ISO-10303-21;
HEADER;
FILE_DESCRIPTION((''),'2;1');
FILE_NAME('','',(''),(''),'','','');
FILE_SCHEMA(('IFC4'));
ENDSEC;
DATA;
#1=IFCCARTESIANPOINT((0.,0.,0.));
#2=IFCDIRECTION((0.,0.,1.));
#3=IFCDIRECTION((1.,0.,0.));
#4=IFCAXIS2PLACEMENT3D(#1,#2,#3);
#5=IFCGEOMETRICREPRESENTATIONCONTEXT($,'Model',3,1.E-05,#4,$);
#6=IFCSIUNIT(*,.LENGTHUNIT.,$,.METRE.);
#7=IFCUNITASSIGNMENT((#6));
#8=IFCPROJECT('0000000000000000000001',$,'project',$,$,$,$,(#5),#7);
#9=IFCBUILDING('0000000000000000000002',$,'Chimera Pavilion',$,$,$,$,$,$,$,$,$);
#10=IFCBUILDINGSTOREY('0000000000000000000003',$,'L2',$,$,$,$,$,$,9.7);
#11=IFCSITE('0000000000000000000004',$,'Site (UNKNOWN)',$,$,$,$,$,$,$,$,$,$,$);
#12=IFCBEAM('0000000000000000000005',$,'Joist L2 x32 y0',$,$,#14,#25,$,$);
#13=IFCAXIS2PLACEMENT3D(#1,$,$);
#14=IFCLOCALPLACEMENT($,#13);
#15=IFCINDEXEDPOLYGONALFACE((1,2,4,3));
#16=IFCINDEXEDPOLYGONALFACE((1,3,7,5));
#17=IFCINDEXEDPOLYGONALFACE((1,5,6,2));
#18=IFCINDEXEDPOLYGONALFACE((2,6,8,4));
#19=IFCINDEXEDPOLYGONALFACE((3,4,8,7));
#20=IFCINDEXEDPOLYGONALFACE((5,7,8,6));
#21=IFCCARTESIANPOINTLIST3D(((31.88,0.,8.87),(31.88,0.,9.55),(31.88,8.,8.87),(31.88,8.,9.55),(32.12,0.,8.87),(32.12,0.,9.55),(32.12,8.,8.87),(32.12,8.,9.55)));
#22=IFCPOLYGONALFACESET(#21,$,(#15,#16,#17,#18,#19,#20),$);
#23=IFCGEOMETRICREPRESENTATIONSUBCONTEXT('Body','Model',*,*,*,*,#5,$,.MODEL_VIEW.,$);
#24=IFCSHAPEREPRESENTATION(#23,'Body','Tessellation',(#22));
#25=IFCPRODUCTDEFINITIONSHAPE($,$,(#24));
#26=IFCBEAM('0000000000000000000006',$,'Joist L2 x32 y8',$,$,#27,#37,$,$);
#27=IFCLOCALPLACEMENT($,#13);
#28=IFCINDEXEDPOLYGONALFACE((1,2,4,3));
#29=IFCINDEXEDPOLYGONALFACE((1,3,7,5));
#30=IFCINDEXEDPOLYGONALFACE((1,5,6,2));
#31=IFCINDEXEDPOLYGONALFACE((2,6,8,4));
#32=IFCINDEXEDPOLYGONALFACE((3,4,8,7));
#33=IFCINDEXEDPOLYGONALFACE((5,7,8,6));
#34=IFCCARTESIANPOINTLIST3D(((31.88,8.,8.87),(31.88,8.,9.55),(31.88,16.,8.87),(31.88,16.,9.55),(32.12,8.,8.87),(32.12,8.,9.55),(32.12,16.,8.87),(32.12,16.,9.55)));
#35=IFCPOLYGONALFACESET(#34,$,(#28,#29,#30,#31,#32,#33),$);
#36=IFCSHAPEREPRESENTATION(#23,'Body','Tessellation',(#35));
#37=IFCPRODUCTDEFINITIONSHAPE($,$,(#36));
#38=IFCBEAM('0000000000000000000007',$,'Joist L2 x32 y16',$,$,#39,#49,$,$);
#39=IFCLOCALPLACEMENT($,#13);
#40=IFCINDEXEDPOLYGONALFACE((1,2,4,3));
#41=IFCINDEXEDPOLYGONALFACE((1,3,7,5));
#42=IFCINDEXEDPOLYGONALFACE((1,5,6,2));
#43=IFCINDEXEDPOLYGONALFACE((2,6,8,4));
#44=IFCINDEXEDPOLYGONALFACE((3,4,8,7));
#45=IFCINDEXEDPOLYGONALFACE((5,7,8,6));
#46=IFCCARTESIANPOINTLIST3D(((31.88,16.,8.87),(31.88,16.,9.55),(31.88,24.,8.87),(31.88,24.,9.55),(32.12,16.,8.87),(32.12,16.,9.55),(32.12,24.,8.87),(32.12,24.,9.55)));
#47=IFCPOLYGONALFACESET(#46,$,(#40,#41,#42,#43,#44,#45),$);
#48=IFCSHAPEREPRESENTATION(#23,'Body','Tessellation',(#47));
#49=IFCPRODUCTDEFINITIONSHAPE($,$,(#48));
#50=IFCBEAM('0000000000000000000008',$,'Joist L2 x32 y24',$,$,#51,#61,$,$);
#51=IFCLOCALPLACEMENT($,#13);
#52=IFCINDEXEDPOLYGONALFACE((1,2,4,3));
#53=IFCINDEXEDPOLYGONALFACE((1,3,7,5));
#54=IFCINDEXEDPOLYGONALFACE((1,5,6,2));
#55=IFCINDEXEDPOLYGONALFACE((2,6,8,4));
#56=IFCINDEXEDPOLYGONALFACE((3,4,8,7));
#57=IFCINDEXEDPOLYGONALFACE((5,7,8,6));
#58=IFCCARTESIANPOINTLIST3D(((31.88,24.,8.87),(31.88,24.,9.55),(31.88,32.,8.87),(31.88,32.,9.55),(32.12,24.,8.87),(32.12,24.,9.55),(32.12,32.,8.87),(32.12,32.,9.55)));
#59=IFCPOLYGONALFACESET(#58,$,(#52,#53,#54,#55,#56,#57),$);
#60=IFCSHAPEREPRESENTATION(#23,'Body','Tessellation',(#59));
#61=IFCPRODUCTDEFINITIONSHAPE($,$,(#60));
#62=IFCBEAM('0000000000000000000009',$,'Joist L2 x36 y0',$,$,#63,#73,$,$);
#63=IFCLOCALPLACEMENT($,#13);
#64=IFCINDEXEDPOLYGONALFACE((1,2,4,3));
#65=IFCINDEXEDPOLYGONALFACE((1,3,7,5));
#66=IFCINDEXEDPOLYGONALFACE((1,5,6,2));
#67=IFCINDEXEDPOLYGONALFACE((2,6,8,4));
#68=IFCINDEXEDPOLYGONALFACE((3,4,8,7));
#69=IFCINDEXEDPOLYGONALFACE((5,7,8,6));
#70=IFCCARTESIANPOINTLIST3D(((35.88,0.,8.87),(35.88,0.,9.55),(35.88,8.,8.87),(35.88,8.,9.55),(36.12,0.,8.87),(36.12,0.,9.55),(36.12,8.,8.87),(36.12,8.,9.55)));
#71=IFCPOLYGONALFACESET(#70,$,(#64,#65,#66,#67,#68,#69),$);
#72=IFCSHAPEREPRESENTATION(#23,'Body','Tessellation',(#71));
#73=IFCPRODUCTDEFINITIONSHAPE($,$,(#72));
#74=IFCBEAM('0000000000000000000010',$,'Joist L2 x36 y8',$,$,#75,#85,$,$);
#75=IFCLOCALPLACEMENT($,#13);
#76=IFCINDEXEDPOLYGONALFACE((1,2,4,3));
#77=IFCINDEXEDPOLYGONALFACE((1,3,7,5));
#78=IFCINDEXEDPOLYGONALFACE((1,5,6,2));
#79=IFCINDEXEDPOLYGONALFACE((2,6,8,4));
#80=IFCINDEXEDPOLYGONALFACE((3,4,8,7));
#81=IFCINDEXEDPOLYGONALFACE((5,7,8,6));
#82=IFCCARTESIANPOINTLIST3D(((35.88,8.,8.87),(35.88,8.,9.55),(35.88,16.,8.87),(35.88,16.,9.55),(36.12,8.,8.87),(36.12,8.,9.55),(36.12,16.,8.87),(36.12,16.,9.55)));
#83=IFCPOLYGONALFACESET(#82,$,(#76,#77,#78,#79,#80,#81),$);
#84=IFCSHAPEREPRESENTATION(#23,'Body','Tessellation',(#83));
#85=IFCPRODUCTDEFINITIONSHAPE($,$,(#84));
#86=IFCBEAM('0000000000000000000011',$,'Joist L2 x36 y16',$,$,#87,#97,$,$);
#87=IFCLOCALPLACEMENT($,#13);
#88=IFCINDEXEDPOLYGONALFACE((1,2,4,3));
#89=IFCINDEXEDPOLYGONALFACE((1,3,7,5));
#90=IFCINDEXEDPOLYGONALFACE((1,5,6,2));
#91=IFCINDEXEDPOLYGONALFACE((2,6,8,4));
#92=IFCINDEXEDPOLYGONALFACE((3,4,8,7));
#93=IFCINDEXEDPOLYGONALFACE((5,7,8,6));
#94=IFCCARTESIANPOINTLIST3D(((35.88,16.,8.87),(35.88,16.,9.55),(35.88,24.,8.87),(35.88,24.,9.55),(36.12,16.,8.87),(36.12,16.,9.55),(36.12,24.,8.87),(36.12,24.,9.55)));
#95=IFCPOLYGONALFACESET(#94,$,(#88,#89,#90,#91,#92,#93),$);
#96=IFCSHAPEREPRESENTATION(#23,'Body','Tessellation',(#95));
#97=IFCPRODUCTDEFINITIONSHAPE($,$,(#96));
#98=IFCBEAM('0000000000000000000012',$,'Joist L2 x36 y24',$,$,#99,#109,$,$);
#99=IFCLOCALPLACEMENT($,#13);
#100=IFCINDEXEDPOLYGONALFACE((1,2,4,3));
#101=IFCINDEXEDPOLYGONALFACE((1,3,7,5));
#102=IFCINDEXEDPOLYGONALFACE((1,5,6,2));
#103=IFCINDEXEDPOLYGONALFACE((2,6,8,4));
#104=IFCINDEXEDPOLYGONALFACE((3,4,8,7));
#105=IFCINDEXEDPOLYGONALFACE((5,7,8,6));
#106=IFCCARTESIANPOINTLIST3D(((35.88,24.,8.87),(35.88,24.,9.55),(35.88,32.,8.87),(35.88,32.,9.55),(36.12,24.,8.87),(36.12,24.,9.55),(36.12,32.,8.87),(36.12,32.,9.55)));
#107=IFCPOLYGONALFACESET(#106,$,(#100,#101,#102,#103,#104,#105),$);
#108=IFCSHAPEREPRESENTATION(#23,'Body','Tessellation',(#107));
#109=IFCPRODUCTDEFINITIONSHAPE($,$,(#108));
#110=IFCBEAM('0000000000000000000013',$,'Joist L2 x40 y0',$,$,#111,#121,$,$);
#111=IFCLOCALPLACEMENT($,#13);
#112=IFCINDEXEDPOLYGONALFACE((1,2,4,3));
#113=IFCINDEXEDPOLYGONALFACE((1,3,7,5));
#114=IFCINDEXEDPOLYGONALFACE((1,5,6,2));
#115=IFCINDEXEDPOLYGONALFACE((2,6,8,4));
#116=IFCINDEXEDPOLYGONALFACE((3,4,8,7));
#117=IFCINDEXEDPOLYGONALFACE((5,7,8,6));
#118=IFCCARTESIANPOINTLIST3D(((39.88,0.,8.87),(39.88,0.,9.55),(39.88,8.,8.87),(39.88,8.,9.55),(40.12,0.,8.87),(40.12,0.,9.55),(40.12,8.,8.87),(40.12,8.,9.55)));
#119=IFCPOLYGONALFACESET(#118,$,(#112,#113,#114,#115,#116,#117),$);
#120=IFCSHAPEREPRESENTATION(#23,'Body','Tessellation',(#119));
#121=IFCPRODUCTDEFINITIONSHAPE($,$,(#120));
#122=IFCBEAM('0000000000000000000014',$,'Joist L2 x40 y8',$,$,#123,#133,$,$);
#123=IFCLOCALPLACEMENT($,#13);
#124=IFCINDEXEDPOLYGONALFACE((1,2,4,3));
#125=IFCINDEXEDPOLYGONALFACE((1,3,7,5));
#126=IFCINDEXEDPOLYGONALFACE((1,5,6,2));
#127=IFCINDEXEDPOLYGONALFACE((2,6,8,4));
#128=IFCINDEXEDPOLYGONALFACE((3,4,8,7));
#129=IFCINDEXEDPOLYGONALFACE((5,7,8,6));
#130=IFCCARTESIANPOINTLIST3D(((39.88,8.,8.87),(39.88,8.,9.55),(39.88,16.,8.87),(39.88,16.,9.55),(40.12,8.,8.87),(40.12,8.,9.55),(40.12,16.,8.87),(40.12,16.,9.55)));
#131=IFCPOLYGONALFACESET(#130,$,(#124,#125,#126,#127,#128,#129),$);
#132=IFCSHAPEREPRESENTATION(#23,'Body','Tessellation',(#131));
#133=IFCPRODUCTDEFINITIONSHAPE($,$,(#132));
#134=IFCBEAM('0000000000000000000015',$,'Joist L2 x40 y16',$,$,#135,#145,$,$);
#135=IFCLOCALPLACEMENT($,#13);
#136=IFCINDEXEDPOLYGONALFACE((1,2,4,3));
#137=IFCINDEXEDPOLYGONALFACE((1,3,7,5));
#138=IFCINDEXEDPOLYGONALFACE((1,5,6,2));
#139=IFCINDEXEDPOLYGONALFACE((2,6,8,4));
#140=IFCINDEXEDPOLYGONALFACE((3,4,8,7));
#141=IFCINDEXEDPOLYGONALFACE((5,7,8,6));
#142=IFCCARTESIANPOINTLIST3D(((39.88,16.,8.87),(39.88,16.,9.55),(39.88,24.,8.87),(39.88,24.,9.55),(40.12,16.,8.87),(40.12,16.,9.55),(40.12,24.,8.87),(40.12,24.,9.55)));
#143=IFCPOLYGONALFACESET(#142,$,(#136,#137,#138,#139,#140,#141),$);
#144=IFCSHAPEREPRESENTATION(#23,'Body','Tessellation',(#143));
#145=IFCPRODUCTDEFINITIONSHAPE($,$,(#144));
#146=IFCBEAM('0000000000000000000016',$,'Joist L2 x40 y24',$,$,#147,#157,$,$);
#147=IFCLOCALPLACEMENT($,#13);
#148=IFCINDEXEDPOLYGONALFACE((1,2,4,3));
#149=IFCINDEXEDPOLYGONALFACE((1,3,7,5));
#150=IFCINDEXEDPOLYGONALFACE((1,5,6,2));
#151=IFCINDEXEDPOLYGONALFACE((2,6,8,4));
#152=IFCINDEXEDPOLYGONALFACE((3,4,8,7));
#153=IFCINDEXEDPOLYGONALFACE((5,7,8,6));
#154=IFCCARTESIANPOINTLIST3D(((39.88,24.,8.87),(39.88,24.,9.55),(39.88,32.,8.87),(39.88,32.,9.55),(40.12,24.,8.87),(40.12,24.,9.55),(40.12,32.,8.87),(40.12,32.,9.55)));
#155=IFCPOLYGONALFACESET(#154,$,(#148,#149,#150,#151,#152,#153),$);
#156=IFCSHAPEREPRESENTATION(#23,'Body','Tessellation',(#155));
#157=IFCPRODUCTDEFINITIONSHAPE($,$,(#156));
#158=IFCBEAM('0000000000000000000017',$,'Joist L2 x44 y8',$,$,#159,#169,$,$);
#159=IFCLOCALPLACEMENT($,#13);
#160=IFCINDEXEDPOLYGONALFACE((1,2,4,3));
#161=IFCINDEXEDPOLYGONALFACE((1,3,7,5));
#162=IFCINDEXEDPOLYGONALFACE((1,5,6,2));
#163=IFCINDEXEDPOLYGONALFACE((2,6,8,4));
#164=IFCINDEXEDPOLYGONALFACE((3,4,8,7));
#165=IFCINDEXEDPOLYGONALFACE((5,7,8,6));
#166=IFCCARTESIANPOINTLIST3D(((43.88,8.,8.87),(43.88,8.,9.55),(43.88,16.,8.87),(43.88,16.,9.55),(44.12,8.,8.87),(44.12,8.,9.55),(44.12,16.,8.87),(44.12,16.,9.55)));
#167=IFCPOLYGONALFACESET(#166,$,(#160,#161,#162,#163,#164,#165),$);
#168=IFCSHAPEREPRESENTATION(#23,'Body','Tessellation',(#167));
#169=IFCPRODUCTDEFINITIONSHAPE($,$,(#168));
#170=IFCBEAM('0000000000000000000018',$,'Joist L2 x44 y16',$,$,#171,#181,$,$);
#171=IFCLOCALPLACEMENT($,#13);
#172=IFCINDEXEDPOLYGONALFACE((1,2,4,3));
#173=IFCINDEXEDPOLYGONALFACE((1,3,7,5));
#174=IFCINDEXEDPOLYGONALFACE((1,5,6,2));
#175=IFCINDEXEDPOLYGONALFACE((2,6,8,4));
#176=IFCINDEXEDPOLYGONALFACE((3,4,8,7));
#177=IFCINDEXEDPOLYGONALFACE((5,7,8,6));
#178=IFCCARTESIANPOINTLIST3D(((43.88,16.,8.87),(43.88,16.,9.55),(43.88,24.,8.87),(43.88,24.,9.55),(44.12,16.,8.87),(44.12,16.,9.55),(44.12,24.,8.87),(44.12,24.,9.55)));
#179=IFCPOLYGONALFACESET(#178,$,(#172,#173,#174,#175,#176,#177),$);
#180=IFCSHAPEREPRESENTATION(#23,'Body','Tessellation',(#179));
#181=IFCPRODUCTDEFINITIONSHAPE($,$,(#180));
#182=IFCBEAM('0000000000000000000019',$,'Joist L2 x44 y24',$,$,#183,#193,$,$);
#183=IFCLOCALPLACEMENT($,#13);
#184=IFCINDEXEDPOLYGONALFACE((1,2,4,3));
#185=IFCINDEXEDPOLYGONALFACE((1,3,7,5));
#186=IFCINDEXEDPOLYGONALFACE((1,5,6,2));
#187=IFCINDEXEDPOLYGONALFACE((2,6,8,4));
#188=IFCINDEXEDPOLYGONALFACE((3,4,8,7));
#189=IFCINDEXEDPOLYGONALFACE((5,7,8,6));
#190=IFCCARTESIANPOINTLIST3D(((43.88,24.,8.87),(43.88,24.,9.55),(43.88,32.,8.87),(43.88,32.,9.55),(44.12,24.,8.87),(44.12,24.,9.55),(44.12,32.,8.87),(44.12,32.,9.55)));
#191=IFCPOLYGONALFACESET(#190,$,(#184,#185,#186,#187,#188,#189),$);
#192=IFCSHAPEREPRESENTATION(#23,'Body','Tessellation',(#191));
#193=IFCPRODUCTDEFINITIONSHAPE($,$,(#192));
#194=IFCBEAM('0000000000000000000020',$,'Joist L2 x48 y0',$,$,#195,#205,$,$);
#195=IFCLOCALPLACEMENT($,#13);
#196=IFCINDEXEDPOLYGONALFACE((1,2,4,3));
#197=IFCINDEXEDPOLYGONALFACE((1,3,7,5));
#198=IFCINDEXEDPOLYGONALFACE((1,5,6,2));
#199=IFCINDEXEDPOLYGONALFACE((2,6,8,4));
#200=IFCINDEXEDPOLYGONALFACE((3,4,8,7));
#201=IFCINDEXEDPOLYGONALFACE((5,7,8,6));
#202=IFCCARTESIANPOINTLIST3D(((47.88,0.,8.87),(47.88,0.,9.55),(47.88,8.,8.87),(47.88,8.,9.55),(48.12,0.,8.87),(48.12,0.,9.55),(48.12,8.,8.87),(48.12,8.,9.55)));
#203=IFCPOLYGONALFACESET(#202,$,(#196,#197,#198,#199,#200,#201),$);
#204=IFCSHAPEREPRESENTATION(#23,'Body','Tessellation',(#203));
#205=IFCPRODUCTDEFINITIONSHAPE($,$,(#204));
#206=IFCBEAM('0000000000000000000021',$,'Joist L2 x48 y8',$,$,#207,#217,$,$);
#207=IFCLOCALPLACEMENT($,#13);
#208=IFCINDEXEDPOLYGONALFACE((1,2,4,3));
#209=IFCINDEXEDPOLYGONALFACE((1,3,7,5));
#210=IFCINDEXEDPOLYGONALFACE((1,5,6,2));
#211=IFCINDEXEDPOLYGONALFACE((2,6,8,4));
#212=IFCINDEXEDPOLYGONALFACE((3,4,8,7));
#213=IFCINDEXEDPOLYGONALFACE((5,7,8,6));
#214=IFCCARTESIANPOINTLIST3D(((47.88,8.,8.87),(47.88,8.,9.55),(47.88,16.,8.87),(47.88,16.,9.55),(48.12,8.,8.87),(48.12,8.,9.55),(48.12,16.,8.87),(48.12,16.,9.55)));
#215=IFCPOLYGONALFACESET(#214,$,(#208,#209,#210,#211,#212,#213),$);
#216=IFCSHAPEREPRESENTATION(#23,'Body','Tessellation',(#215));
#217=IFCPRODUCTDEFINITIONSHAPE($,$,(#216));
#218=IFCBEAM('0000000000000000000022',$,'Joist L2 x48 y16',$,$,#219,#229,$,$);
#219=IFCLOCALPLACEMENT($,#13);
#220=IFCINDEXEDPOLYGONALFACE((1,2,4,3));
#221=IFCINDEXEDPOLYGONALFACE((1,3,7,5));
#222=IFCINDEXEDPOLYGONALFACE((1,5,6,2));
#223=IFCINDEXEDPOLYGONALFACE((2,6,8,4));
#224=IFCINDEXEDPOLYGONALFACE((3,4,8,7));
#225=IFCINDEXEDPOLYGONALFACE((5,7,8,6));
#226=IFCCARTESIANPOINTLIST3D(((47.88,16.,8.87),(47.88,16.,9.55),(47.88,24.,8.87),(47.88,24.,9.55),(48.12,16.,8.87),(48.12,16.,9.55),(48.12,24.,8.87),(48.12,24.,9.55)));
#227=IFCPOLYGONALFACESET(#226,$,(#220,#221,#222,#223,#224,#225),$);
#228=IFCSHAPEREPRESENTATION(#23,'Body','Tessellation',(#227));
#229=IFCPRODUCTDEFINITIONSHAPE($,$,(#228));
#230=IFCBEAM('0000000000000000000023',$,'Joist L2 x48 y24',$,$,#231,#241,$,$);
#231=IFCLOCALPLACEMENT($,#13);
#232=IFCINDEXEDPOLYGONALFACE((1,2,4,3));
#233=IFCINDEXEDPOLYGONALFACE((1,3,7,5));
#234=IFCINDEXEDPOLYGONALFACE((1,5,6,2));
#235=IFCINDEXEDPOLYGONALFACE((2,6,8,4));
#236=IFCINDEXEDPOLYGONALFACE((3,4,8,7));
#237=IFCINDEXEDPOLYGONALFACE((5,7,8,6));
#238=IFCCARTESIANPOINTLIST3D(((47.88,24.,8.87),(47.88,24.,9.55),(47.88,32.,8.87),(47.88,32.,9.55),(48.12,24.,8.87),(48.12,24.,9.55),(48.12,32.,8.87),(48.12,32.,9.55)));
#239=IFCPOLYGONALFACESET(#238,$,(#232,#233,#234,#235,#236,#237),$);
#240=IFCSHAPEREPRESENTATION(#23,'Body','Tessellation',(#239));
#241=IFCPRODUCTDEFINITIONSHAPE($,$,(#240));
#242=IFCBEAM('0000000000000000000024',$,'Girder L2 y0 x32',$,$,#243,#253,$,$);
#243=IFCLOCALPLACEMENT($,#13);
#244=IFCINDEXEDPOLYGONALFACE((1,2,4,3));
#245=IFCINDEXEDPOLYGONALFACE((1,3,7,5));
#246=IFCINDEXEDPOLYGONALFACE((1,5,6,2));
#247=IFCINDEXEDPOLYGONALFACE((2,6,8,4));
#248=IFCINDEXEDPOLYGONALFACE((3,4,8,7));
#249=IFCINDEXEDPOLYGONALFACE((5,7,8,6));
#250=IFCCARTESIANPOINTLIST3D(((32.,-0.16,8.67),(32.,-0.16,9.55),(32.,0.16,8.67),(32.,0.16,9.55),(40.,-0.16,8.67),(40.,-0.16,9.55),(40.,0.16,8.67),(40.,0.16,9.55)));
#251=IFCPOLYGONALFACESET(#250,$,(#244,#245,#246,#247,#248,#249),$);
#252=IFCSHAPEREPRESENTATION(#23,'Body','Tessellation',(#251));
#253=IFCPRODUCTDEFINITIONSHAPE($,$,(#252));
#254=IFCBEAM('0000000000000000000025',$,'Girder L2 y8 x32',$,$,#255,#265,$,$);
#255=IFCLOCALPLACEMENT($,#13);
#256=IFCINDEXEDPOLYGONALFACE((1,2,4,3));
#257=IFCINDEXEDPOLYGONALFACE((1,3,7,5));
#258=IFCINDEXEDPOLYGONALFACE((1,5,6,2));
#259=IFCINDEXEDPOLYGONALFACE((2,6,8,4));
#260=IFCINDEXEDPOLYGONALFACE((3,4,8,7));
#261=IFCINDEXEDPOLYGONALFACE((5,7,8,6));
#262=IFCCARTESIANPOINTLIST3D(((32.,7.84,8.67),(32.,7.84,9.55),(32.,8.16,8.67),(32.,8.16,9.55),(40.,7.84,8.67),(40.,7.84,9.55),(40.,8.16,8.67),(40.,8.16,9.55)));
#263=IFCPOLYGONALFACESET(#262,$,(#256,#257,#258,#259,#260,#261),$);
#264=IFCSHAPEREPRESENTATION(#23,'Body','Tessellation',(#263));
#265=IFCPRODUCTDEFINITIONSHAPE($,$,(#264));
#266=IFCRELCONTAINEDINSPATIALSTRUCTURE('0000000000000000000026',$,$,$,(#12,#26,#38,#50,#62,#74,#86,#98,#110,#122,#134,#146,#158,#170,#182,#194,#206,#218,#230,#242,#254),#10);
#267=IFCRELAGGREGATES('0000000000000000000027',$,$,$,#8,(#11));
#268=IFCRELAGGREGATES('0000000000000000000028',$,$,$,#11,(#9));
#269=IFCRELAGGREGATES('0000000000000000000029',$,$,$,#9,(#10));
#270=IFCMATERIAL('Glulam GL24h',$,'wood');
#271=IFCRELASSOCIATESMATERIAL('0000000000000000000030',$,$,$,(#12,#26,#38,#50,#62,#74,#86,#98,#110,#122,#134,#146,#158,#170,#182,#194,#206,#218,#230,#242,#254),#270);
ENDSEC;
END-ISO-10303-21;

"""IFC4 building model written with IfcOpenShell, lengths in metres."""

from ifc_helpers import new_model, si_unit, frame, origin_with_axes, place, context, subcontext, project, spatial, rectangle, extrude, material, element, save


model = new_model("IFC4")

# Units and contexts
model_context = context("Model", 3, precision=1e-05, world=origin_with_axes())
body_context = subcontext(model_context, "Body", "Model", "MODEL_VIEW")
ifc_project = project(units=[si_unit("LENGTHUNIT", "METRE")], contexts=[model_context])

# Site, building, storey
site = spatial("IfcSite", under=ifc_project, Name="Site (UNKNOWN)")
building = spatial("IfcBuilding", under=site, Name="Chimera Pavilion")
storey = spatial("IfcBuildingStorey", under=building, Name="L2", Elevation=9.7)

# Beams
ifc_material_1 = material(Name="Glulam GL24h", Category="wood")
for number, where, z_axis, x_axis, name in (
    (1, (32.0, 0.0, 9.21), (0.0, 1.0, 0.0), (1.0, 0.0, 0.0), "Joist L2 x32 y0"),
    (2, (32.0, 8.0, 9.21), (0.0, 1.0, 0.0), (1.0, 0.0, 0.0), "Joist L2 x32 y8"),
    (3, (32.0, 16.0, 9.21), (0.0, 1.0, 0.0), (1.0, 0.0, 0.0), "Joist L2 x32 y16"),
    (4, (32.0, 24.0, 9.21), (0.0, 1.0, 0.0), (1.0, 0.0, 0.0), "Joist L2 x32 y24"),
    (5, (36.0, 0.0, 9.21), (0.0, 1.0, 0.0), (1.0, 0.0, 0.0), "Joist L2 x36 y0"),
    (6, (36.0, 8.0, 9.21), (0.0, 1.0, 0.0), (1.0, 0.0, 0.0), "Joist L2 x36 y8"),
    (7, (36.0, 16.0, 9.21), (0.0, 1.0, 0.0), (1.0, 0.0, 0.0), "Joist L2 x36 y16"),
    (8, (36.0, 24.0, 9.21), (0.0, 1.0, 0.0), (1.0, 0.0, 0.0), "Joist L2 x36 y24"),
    (9, (40.0, 0.0, 9.21), (0.0, 1.0, 0.0), (1.0, 0.0, 0.0), "Joist L2 x40 y0"),
    (10, (40.0, 8.0, 9.21), (0.0, 1.0, 0.0), (1.0, 0.0, 0.0), "Joist L2 x40 y8"),
    (11, (40.0, 16.0, 9.21), (0.0, 1.0, 0.0), (1.0, 0.0, 0.0), "Joist L2 x40 y16"),
    (12, (40.0, 24.0, 9.21), (0.0, 1.0, 0.0), (1.0, 0.0, 0.0), "Joist L2 x40 y24"),
    (13, (44.0, 8.0, 9.21), (0.0, 1.0, 0.0), (1.0, 0.0, 0.0), "Joist L2 x44 y8"),
    (14, (44.0, 16.0, 9.21), (0.0, 1.0, 0.0), (1.0, 0.0, 0.0), "Joist L2 x44 y16"),
    (15, (44.0, 24.0, 9.21), (0.0, 1.0, 0.0), (1.0, 0.0, 0.0), "Joist L2 x44 y24"),
    (16, (48.0, 0.0, 9.21), (0.0, 1.0, 0.0), (1.0, 0.0, 0.0), "Joist L2 x48 y0"),
    (17, (48.0, 8.0, 9.21), (0.0, 1.0, 0.0), (1.0, 0.0, 0.0), "Joist L2 x48 y8"),
    (18, (48.0, 16.0, 9.21), (0.0, 1.0, 0.0), (1.0, 0.0, 0.0), "Joist L2 x48 y16"),
    (19, (48.0, 24.0, 9.21), (0.0, 1.0, 0.0), (1.0, 0.0, 0.0), "Joist L2 x48 y24"),
):
    element("IfcBeam", number, at=place(None, frame(where, z_axis=z_axis, x_axis=x_axis)), inside=storey, material=ifc_material_1, Name=name, context=body_context, shape_type="SweptSolid", body=[
        extrude(rectangle(XDim=0.24, YDim=0.68), origin_with_axes(), (0.0, 0.0, 1.0), 8.0),
    ])
for number, where, z_axis, x_axis, name in (
    (20, (32.0, 0.0, 9.11), (1.0, 0.0, 0.0), (0.0, -1.0, 0.0), "Girder L2 y0 x32"),
    (21, (32.0, 8.0, 9.11), (1.0, 0.0, 0.0), (0.0, -1.0, 0.0), "Girder L2 y8 x32"),
):
    element("IfcBeam", number, at=place(None, frame(where, z_axis=z_axis, x_axis=x_axis)), inside=storey, material=ifc_material_1, Name=name, context=body_context, shape_type="SweptSolid", body=[
        extrude(rectangle(XDim=0.32, YDim=0.88), origin_with_axes(), (0.0, 0.0, 1.0), 8.0),
    ])

save(model, "model.ifc")
